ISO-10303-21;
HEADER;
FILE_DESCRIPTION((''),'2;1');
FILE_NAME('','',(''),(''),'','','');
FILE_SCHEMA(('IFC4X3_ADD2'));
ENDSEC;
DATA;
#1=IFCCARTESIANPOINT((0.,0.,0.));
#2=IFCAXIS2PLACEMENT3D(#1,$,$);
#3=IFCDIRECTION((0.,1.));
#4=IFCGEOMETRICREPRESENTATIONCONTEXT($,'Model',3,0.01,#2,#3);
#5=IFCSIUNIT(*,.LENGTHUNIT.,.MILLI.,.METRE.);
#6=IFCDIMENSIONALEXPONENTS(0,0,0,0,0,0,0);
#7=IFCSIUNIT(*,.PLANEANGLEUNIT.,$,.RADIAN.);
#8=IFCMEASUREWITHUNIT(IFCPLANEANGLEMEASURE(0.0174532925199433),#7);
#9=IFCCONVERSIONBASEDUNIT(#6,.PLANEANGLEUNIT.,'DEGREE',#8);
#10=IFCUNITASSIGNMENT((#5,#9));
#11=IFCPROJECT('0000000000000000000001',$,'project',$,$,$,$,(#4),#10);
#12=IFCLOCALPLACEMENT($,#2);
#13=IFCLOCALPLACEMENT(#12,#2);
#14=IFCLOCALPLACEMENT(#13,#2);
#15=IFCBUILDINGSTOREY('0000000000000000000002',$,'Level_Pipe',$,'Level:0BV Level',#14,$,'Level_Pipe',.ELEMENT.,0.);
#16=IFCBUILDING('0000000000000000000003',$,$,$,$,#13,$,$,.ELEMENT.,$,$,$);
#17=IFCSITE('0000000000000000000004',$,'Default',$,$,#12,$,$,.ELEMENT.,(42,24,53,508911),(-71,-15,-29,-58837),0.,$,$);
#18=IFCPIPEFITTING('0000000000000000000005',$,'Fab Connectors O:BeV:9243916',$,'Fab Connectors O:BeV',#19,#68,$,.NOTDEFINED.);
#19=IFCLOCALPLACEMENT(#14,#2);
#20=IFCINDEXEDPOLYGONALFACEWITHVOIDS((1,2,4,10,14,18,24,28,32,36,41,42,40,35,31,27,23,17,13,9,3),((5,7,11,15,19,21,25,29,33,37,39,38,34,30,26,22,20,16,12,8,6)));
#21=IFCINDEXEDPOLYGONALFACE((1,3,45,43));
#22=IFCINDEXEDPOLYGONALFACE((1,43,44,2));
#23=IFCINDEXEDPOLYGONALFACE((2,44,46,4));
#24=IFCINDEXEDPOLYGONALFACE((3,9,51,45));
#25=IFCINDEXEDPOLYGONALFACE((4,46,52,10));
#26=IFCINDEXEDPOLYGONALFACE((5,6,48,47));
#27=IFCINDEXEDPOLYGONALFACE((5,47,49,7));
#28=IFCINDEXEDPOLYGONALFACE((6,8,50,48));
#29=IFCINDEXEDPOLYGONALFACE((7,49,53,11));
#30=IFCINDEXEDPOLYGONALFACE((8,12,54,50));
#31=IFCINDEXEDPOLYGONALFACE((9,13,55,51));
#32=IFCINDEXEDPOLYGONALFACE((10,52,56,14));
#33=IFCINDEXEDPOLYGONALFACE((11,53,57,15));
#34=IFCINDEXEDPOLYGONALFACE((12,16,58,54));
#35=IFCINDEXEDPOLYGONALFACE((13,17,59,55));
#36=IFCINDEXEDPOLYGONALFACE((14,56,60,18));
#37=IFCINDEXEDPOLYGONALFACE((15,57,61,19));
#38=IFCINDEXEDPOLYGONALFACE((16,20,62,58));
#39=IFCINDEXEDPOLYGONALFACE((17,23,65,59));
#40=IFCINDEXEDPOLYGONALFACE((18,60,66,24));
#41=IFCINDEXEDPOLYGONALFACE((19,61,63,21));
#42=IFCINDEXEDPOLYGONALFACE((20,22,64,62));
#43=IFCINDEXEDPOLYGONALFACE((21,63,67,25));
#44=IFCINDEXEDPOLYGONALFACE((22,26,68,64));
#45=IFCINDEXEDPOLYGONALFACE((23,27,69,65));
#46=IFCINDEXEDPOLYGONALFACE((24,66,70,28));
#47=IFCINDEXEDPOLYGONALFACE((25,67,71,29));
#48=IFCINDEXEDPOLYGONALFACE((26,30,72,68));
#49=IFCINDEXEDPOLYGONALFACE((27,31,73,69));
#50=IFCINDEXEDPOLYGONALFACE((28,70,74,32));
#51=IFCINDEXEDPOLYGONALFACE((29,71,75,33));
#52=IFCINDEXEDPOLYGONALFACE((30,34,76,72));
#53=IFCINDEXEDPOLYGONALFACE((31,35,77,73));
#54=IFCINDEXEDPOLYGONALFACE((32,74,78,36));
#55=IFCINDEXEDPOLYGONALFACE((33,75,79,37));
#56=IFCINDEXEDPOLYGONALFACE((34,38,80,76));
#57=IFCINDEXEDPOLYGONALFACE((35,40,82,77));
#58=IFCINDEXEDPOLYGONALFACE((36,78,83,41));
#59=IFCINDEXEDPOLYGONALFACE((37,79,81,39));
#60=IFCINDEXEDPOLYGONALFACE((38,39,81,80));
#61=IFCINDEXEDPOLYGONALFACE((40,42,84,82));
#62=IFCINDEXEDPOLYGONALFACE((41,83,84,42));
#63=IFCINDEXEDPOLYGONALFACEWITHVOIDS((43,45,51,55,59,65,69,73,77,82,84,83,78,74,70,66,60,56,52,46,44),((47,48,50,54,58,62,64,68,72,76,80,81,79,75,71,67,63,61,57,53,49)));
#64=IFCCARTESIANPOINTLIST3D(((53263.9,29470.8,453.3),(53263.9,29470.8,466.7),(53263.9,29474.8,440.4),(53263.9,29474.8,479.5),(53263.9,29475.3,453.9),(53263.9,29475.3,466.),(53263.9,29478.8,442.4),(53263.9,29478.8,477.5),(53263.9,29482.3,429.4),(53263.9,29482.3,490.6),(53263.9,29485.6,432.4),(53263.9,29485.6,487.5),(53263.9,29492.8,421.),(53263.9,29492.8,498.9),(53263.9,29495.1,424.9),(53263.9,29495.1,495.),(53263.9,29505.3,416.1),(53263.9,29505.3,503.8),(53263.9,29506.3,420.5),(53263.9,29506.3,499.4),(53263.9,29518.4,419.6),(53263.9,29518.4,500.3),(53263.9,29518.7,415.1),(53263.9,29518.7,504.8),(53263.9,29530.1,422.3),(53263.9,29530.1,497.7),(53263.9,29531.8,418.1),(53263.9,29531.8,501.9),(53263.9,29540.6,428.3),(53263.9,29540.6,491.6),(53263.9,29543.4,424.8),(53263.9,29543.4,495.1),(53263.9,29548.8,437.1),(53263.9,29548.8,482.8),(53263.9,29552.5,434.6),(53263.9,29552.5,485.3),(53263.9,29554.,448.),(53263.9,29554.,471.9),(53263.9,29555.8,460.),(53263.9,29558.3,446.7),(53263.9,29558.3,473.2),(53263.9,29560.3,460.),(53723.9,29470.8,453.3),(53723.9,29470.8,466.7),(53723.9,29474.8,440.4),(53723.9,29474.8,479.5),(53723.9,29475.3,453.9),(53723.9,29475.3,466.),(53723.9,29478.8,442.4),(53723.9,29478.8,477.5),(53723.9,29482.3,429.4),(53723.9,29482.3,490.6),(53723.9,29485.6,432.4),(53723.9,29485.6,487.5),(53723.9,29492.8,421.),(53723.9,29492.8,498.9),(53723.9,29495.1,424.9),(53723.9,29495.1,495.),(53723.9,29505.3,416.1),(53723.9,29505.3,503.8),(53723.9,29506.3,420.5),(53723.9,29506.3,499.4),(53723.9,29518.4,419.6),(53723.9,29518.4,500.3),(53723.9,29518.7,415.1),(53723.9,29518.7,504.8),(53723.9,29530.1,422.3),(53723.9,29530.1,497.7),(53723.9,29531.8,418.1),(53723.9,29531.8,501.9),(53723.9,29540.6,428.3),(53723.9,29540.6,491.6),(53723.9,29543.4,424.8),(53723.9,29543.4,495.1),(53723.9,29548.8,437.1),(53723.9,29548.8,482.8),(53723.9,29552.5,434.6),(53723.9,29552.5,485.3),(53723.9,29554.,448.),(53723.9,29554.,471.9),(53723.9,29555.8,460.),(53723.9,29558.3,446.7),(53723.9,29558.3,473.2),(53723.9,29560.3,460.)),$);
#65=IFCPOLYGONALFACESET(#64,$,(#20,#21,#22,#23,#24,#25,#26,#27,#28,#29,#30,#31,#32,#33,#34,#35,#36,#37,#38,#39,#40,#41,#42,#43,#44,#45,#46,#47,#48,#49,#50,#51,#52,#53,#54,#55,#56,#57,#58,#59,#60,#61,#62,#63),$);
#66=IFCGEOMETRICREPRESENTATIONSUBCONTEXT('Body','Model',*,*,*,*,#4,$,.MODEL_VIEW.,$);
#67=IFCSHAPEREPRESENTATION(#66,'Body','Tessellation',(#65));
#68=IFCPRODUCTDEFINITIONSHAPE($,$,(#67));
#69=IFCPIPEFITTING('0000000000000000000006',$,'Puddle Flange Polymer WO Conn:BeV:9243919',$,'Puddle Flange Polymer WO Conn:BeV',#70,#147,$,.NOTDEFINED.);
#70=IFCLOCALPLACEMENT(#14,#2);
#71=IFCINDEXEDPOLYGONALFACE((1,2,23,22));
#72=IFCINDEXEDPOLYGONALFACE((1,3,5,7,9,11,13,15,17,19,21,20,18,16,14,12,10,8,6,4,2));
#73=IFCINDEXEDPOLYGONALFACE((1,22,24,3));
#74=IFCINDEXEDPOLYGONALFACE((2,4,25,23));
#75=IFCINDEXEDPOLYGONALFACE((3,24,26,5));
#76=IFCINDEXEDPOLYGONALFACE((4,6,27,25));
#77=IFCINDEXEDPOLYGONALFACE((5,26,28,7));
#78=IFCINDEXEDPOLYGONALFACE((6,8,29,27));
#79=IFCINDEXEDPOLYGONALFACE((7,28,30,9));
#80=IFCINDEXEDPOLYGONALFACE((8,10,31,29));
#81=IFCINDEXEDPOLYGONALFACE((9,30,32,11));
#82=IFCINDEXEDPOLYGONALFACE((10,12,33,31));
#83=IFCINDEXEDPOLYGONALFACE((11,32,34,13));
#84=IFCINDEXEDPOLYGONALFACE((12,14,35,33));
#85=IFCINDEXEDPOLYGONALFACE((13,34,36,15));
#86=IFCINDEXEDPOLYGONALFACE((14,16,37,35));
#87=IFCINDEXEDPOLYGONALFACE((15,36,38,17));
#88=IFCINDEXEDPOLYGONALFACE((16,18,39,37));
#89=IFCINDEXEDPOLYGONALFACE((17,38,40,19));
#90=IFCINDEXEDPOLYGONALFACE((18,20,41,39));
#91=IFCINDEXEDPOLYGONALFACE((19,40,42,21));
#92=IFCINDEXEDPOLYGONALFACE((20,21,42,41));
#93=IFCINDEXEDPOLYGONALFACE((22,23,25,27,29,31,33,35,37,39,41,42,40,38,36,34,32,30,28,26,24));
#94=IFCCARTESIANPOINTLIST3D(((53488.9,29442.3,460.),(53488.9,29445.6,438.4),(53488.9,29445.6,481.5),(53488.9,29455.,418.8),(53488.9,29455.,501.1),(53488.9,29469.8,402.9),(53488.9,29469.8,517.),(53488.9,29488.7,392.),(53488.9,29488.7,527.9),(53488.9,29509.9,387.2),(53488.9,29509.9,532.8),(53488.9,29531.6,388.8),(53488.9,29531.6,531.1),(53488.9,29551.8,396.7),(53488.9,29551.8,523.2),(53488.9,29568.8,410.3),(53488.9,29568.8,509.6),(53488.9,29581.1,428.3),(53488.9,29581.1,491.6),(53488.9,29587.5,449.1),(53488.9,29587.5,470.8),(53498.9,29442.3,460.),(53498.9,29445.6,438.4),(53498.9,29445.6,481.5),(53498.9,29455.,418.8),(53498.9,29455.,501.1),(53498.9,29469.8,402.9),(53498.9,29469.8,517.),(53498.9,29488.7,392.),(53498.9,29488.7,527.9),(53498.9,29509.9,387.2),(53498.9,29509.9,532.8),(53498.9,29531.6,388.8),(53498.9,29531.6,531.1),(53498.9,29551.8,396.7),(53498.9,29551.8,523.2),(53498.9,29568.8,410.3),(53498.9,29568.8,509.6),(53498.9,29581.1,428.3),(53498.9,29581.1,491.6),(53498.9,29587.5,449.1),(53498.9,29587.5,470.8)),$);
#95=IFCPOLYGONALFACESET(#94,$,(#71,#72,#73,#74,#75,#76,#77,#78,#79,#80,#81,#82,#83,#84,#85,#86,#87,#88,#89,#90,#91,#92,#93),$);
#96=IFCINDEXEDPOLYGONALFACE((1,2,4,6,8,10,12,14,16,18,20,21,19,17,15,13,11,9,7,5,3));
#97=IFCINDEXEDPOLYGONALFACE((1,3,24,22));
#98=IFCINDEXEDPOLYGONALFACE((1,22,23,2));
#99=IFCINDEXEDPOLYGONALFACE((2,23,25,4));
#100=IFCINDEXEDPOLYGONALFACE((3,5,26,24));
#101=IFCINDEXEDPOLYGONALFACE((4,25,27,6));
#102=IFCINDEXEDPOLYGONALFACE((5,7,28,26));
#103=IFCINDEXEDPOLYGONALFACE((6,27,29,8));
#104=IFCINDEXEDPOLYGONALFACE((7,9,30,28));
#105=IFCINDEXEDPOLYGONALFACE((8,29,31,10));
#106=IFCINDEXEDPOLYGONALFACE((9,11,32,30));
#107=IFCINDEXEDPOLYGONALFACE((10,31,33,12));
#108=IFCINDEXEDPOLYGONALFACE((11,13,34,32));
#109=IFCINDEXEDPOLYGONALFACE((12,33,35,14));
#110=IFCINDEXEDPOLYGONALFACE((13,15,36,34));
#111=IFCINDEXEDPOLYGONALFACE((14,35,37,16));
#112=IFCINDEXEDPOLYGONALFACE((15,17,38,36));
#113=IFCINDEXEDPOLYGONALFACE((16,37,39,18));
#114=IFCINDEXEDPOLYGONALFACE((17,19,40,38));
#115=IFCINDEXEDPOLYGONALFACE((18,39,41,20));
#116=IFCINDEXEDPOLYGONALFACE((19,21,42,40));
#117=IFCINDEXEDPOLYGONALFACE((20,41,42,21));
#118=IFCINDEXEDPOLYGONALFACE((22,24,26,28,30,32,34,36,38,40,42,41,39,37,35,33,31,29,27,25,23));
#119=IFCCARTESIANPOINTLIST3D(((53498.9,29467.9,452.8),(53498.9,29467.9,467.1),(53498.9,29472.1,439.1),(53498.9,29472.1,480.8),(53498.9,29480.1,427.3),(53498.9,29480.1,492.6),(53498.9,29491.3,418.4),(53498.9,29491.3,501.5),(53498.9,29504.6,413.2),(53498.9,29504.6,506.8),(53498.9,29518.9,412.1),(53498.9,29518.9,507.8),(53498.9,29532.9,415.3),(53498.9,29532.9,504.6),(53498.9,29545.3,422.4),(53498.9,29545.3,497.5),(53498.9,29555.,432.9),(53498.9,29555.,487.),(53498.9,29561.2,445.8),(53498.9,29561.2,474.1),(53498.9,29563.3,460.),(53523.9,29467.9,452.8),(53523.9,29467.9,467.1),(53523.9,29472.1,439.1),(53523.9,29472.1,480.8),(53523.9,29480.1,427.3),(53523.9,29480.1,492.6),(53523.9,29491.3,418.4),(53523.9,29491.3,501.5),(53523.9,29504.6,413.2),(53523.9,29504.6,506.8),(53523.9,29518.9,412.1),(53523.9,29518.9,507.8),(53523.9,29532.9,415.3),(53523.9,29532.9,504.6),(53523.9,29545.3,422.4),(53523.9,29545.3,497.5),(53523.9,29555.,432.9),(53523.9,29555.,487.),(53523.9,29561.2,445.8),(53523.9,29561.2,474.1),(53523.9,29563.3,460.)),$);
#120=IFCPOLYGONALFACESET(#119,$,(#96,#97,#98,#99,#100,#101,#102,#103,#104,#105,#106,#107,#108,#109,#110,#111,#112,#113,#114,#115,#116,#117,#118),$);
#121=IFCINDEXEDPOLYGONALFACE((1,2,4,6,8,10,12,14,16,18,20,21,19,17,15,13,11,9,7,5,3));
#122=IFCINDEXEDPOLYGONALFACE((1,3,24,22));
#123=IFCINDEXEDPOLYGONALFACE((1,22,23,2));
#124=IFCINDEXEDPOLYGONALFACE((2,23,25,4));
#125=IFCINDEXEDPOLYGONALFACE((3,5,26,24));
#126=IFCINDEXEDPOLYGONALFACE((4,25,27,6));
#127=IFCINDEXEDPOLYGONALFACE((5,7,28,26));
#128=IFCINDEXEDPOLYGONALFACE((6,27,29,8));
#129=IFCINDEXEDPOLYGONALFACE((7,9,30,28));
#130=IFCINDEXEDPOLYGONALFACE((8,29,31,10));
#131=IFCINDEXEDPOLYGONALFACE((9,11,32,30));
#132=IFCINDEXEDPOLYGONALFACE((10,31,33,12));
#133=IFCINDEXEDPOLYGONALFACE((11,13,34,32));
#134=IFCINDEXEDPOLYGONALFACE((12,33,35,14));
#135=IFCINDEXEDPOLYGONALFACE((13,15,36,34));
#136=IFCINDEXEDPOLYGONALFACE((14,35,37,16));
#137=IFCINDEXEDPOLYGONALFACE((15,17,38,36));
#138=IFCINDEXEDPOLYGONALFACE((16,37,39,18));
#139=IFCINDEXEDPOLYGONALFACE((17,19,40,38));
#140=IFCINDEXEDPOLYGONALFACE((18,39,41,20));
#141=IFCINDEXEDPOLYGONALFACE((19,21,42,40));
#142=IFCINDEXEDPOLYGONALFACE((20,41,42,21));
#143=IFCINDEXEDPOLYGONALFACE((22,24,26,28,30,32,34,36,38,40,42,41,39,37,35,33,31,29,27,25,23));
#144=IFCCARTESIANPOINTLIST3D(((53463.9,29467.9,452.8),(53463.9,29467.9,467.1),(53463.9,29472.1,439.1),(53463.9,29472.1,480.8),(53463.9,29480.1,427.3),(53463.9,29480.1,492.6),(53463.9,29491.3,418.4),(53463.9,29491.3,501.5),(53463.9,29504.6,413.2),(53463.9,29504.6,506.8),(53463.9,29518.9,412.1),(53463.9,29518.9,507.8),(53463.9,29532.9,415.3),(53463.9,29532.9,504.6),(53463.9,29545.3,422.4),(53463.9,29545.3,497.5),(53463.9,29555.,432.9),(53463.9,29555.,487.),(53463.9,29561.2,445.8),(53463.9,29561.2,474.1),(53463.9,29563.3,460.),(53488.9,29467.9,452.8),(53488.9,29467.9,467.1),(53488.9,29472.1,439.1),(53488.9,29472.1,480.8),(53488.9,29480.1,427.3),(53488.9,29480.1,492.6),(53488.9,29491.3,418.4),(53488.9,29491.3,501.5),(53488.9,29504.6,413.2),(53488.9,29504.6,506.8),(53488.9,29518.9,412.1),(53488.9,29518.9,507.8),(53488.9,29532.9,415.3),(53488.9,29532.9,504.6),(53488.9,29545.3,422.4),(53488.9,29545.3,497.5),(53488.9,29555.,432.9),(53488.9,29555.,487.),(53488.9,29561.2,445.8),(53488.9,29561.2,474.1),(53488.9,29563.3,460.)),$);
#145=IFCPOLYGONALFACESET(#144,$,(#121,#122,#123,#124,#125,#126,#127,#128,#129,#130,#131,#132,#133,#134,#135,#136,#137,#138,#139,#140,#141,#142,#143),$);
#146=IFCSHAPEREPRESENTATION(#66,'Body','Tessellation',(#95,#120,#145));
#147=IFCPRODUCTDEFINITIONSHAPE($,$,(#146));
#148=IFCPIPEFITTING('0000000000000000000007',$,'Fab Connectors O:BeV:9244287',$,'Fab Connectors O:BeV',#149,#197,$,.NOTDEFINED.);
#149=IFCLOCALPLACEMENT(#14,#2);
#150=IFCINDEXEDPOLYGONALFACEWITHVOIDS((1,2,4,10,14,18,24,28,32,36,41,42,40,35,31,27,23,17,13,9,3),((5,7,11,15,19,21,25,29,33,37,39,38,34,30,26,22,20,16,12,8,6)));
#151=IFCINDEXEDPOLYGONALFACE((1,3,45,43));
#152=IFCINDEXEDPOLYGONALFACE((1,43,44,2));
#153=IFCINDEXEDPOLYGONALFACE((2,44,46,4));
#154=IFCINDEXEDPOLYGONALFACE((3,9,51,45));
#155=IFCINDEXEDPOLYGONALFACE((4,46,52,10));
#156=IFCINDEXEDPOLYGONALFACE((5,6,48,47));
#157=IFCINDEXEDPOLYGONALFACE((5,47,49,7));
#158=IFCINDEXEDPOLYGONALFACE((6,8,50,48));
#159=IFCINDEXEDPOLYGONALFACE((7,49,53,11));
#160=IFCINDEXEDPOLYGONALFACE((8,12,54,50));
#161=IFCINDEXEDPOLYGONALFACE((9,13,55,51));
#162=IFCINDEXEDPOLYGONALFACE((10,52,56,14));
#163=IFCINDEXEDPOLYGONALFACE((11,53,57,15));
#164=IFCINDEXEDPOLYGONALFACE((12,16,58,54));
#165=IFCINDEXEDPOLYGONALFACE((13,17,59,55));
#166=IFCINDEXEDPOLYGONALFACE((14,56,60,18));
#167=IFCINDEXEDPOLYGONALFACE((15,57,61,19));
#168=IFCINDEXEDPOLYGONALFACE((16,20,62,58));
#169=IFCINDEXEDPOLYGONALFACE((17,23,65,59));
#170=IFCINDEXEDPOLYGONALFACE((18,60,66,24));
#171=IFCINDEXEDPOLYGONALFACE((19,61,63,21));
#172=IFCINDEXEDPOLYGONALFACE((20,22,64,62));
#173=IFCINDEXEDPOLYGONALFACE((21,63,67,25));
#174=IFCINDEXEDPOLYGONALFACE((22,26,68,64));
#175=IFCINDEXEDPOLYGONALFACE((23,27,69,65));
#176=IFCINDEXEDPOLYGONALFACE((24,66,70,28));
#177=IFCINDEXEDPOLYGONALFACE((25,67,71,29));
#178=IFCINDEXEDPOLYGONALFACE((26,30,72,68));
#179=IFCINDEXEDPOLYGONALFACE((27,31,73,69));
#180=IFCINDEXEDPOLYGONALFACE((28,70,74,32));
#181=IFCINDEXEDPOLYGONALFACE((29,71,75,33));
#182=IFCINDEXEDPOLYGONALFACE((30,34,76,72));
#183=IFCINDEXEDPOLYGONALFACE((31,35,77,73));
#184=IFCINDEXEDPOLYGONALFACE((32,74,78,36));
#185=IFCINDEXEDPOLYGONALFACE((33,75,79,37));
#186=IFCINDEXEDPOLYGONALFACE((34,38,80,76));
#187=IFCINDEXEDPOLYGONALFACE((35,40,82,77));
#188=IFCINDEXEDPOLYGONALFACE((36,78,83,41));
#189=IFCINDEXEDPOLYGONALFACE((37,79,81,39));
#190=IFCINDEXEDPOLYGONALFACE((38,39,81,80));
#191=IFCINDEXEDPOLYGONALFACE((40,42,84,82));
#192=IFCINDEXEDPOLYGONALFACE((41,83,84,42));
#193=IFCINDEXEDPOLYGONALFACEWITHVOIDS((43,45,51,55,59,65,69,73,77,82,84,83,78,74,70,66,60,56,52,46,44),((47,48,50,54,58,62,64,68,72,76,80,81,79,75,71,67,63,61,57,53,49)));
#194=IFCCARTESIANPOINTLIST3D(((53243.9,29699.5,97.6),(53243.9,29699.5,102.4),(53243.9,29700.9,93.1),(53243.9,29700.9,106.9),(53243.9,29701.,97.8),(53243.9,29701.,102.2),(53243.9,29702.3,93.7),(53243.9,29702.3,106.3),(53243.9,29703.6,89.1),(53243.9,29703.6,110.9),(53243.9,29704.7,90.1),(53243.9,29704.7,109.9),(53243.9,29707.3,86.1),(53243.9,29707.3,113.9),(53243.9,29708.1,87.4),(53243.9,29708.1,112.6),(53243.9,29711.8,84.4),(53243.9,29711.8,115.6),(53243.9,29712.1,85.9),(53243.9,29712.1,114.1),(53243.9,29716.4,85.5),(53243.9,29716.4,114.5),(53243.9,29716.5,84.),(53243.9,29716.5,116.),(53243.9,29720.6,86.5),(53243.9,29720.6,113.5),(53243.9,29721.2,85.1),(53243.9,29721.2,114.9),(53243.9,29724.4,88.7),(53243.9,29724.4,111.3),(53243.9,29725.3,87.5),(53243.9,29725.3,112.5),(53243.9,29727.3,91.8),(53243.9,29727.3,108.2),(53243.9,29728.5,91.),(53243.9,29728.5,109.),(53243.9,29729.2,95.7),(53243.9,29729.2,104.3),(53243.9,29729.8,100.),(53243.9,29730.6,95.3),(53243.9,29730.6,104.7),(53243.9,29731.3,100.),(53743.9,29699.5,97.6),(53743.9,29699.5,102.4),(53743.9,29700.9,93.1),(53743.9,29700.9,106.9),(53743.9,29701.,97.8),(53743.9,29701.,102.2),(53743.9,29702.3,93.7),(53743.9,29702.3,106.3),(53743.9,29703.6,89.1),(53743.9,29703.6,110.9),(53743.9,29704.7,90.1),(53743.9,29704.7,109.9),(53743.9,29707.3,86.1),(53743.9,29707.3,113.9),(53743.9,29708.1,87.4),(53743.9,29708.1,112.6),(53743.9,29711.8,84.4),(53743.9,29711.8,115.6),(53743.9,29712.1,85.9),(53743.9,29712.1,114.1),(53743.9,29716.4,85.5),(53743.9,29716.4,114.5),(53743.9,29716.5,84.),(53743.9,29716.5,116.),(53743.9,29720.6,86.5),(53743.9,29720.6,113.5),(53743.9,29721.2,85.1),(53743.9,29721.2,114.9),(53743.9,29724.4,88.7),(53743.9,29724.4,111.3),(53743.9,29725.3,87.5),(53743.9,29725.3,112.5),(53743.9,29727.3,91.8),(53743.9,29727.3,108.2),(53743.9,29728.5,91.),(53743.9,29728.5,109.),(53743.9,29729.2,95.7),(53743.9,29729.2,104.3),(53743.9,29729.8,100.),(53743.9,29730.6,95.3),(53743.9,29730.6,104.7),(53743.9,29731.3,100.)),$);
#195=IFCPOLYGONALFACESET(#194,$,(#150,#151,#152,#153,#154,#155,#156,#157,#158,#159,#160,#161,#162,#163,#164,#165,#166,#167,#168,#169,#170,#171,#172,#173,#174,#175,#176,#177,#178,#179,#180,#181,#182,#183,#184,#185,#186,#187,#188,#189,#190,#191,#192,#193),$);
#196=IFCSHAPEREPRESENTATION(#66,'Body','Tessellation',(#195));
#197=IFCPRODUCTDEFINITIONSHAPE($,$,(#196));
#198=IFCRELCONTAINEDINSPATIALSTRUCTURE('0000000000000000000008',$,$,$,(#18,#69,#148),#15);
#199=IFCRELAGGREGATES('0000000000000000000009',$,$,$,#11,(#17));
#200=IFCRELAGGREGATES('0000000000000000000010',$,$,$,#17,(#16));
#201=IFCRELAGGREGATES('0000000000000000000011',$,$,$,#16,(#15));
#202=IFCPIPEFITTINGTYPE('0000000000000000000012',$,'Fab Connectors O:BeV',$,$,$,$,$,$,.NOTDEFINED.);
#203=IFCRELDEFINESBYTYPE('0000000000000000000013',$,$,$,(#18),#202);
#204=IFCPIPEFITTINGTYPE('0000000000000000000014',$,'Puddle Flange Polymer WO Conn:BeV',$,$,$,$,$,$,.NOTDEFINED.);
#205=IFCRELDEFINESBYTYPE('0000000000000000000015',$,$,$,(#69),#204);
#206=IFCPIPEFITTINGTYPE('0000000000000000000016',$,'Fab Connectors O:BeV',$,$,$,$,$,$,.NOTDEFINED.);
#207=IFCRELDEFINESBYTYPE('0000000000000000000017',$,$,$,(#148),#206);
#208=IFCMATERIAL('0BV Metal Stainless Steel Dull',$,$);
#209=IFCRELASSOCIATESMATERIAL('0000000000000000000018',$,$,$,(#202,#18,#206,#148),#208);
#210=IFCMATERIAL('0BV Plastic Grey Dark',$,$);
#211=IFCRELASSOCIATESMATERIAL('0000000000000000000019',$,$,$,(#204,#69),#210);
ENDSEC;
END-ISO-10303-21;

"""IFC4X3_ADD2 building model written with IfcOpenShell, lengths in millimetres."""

from ifc_helpers import new_model, entity, si_unit, converted_unit, direction, frame, frame_2d, origin, place, context, subcontext, project, spatial, circle, hollow_circle, extrude, source, transform, mapped, material, type_object, type_shapes, element, save


model = new_model("IFC4X3_ADD2")

# Units and contexts
model_context = context("Model", 3, precision=0.01, world=origin(), true_north=direction((0.0, 1.0)))
body_context = subcontext(model_context, "Body", "Model", "MODEL_VIEW")
ifc_project = project(units=[si_unit("LENGTHUNIT", "METRE", prefix="MILLI"), converted_unit("PLANEANGLEUNIT", "DEGREE", entity("IfcPlaneAngleMeasure", 0.0174532925199433), si_unit("PLANEANGLEUNIT", "RADIAN"), dimensions=[0, 0, 0, 0, 0, 0, 0])], contexts=[model_context])

# Site, building, storey
site_placement = place(None, origin())
site = spatial("IfcSite", under=ifc_project, at=site_placement, Name="Default", CompositionType="ELEMENT", RefLatitude=(42, 24, 53, 508911), RefLongitude=(-71, -15, -29, -58837), RefElevation=0.0)
building_placement = place(site_placement, origin())
building = spatial("IfcBuilding", under=site, at=building_placement, CompositionType="ELEMENT")
storey_placement = place(building_placement, origin())
storey = spatial("IfcBuildingStorey", under=building, at=storey_placement, Name="Level_Pipe", ObjectType="Level:0BV Level", LongName="Level_Pipe", CompositionType="ELEMENT", Elevation=0.0)

# Shared definitions
ifc_material_1 = material(Name="0BV Metal Stainless Steel Dull")

# Pipe fittings
pipe_fitting_type_1 = type_object("IfcPipeFittingType", Name="Fab Connectors O:BeV", PredefinedType="NOTDEFINED", material=ifc_material_1)
shared_shape_1 = source(origin(), body_context, "Body", "SweptSolid", [
    extrude(hollow_circle(Radius=45.0, WallThickness=4.5, at=frame_2d((0.0, 0.0), x_axis=(1.0, 0.0))), frame((0.0, 46.6, 46.6), z_axis=(1.0, 0.0, 0.0), x_axis=(0.0, 1.0, 0.0)), (0.0, 0.0, 1.0), 460.0),
])
type_shapes(pipe_fitting_type_1, [shared_shape_1])
pipe_fitting_1_placement = place(storey_placement, frame((53263.9, 29468.7, 413.4)))
element("IfcPipeFitting", 1, at=pipe_fitting_1_placement, inside=storey, type_object=pipe_fitting_type_1, material=ifc_material_1, Name="Fab Connectors O:BeV:9243916", ObjectType="Fab Connectors O:BeV", PredefinedType="NOTDEFINED", context=body_context, shape_type="MappedRepresentation", body=[
    mapped(shared_shape_1, transform((0.0, 0.0, 0.0), scale=1.0)),
])
ifc_material_2 = material(Name="0BV Plastic Grey Dark")
pipe_fitting_type_2 = type_object("IfcPipeFittingType", Name="Puddle Flange Polymer WO Conn:BeV", PredefinedType="NOTDEFINED", material=ifc_material_2)
shared_shape_2 = source(origin(), body_context, "Body", "SweptSolid", [
    extrude(circle(Radius=73.0, at=frame_2d((0.0, 0.0), x_axis=(1.0, 0.0))), frame((-5.0, 0.0, 0.0), z_axis=(1.0, 0.0, 0.0), x_axis=(0.0, -1.0, 0.0)), (0.0, 0.0, 1.0), 10.0),
    extrude(circle(Radius=48.0, at=frame_2d((0.0, 0.0), x_axis=(1.0, 0.0))), frame((5.0, 0.0, 0.0), z_axis=(1.0, 0.0, 0.0), x_axis=(0.0, 1.0, 0.0)), (0.0, 0.0, 1.0), 25.0),
    extrude(circle(Radius=48.0, at=frame_2d((0.0, 0.0), x_axis=(1.0, 0.0))), frame((-30.0, 0.0, 0.0), z_axis=(1.0, 0.0, 0.0), x_axis=(0.0, 1.0, 0.0)), (0.0, 0.0, 1.0), 25.0),
])
type_shapes(pipe_fitting_type_2, [shared_shape_2])
pipe_fitting_2_placement = place(storey_placement, frame((53493.9, 29515.3, 460.0)))
element("IfcPipeFitting", 2, at=pipe_fitting_2_placement, inside=storey, type_object=pipe_fitting_type_2, material=ifc_material_2, Name="Puddle Flange Polymer WO Conn:BeV:9243919", ObjectType="Puddle Flange Polymer WO Conn:BeV", PredefinedType="NOTDEFINED", context=body_context, shape_type="MappedRepresentation", body=[
    mapped(shared_shape_2, transform((0.0, 0.0, 0.0), scale=1.0)),
])
pipe_fitting_type_3 = type_object("IfcPipeFittingType", Name="Fab Connectors O:BeV", PredefinedType="NOTDEFINED", material=ifc_material_1)
shared_shape_3 = source(origin(), body_context, "Body", "SweptSolid", [
    extrude(hollow_circle(Radius=16.0, WallThickness=1.5, at=frame_2d((0.0, 0.0), x_axis=(1.0, 0.0))), frame((0.0, 0.0, 0.0), z_axis=(1.0, 0.0, 0.0), x_axis=(0.0, 1.0, 0.0)), (0.0, 0.0, 1.0), 500.0),
])
type_shapes(pipe_fitting_type_3, [shared_shape_3])
pipe_fitting_3_placement = place(storey_placement, frame((53243.9, 29715.3, 100.0)))
element("IfcPipeFitting", 3, at=pipe_fitting_3_placement, inside=storey, type_object=pipe_fitting_type_3, material=ifc_material_1, Name="Fab Connectors O:BeV:9244287", ObjectType="Fab Connectors O:BeV", PredefinedType="NOTDEFINED", context=body_context, shape_type="MappedRepresentation", body=[
    mapped(shared_shape_3, transform((0.0, 0.0, 0.0), scale=1.0)),
])

save(model, "model.ifc")
